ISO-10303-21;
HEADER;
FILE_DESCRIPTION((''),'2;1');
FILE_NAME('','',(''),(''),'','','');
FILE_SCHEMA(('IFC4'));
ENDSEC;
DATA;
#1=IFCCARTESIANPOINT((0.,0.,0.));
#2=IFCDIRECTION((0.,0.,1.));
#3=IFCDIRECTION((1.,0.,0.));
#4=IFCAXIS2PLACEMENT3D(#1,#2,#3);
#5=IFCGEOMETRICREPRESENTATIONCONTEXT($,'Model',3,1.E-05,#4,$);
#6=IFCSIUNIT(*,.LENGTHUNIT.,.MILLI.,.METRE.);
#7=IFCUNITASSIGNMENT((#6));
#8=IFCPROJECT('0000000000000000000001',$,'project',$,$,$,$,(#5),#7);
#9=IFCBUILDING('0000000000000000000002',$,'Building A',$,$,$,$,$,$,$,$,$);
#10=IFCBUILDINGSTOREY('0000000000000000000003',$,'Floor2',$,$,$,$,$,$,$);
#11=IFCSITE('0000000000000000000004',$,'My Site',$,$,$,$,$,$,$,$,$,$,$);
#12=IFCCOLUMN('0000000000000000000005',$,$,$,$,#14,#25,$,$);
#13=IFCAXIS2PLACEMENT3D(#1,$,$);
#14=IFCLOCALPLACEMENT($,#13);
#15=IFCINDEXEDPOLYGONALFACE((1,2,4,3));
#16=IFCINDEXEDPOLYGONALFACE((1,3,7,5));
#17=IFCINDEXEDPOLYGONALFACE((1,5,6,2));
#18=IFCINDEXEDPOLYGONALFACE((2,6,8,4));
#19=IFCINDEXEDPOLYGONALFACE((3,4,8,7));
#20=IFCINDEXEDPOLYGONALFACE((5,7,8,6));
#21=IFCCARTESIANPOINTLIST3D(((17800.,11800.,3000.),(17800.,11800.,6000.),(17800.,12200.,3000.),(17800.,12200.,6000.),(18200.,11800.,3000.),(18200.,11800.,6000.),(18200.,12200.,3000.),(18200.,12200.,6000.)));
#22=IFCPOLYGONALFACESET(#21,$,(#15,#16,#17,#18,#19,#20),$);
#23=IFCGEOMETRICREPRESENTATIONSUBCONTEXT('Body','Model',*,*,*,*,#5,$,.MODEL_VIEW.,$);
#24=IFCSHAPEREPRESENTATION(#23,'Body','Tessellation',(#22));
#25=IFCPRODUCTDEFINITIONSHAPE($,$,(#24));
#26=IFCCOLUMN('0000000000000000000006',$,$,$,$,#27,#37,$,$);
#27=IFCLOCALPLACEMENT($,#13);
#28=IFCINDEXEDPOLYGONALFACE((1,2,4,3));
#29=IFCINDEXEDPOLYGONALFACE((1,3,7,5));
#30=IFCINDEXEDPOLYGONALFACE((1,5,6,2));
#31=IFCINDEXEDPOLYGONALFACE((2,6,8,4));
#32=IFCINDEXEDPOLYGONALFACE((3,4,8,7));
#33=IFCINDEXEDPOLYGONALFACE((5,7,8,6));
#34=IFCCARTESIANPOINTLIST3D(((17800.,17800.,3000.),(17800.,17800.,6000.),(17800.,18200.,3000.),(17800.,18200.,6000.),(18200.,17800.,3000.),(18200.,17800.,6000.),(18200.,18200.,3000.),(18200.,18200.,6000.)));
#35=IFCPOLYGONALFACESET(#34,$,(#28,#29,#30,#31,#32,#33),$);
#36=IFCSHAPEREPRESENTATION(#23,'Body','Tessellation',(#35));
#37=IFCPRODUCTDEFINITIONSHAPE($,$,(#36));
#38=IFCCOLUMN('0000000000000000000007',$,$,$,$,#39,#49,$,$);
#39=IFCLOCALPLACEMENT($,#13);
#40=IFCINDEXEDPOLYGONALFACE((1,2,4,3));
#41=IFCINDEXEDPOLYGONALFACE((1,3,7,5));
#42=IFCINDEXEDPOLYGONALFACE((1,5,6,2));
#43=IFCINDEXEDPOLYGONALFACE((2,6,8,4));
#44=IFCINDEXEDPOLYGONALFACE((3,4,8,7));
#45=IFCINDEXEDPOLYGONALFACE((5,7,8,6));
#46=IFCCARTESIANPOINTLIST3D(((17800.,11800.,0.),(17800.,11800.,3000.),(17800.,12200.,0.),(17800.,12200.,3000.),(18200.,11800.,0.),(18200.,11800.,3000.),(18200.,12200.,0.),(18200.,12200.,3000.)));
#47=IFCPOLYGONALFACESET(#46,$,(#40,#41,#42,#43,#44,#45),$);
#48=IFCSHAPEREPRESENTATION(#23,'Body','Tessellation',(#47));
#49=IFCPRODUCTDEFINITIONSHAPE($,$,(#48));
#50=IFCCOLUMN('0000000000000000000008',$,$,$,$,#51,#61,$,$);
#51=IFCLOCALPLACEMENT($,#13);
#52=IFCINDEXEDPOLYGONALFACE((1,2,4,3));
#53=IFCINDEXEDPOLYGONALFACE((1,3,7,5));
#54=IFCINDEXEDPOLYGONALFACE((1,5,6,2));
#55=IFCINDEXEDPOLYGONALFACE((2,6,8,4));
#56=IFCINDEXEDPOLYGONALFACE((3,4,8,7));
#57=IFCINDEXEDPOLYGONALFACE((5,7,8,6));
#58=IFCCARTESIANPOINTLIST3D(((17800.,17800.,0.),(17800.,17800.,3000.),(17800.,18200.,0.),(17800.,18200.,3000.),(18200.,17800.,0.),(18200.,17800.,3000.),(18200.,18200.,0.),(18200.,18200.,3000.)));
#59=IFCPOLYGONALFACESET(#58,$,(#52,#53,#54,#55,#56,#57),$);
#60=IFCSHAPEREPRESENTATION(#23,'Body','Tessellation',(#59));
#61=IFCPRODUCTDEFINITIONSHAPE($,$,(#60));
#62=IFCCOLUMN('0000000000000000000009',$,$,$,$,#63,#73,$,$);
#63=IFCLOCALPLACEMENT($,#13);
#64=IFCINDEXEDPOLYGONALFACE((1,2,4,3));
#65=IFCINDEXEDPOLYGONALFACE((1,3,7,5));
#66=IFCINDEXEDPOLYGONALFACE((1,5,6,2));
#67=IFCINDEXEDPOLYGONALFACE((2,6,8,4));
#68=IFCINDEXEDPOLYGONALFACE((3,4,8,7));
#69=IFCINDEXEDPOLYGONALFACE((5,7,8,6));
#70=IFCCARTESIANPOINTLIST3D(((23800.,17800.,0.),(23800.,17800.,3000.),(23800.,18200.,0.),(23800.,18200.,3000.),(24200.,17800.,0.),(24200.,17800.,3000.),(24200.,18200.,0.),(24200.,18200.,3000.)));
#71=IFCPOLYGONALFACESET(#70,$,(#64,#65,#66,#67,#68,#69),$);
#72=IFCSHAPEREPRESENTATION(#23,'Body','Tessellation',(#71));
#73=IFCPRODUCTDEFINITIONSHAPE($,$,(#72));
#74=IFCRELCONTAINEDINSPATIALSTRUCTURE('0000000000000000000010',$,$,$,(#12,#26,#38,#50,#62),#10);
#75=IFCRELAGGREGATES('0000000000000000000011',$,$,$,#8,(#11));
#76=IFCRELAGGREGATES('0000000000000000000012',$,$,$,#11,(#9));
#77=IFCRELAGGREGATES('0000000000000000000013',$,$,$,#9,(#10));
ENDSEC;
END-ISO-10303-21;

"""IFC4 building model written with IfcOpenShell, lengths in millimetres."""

from ifc_helpers import new_model, si_unit, frame, origin_with_axes, place, context, subcontext, project, spatial, line, indexed_curve, outline, extrude, element, save


model = new_model("IFC4")

# Units and contexts
model_context = context("Model", 3, precision=1e-05, world=origin_with_axes())
body_context = subcontext(model_context, "Body", "Model", "MODEL_VIEW")
ifc_project = project(units=[si_unit("LENGTHUNIT", "METRE", prefix="MILLI")], contexts=[model_context])

# Site, building, storey
site = spatial("IfcSite", under=ifc_project, Name="My Site")
building = spatial("IfcBuilding", under=site, Name="Building A")
storey = spatial("IfcBuildingStorey", under=building, Name="Floor2")

# Columns
for number, where, z_axis, x_axis in (
    (1, (18000.0, 12000.0, 3000.0), (0.0, 0.0, 1.0), (1.0, 0.0, 0.0)),
    (2, (18000.0, 18000.0, 3000.0), (0.0, 0.0, 1.0), (1.0, 0.0, 0.0)),
    (3, (18000.0, 12000.0, 0.0), (0.0, 0.0, 1.0), (1.0, 0.0, 0.0)),
    (4, (18000.0, 18000.0, 0.0), (0.0, 0.0, 1.0), (1.0, 0.0, 0.0)),
    (5, (24000.0, 18000.0, 0.0), (0.0, 0.0, 1.0), (1.0, 0.0, 0.0)),
):
    element("IfcColumn", number, at=place(None, frame(where, z_axis=z_axis, x_axis=x_axis)), inside=storey, context=body_context, shape_type="SweptSolid", body=[
        extrude(outline(indexed_curve([(-200.0, -200.0), (200.0, -200.0), (200.0, 200.0), (-200.0, 200.0)], segments=[line(1, 2, 3, 4, 1)])), origin_with_axes(), (0.0, 0.0, 1.0), 3000.0),
    ])

save(model, "model.ifc")
